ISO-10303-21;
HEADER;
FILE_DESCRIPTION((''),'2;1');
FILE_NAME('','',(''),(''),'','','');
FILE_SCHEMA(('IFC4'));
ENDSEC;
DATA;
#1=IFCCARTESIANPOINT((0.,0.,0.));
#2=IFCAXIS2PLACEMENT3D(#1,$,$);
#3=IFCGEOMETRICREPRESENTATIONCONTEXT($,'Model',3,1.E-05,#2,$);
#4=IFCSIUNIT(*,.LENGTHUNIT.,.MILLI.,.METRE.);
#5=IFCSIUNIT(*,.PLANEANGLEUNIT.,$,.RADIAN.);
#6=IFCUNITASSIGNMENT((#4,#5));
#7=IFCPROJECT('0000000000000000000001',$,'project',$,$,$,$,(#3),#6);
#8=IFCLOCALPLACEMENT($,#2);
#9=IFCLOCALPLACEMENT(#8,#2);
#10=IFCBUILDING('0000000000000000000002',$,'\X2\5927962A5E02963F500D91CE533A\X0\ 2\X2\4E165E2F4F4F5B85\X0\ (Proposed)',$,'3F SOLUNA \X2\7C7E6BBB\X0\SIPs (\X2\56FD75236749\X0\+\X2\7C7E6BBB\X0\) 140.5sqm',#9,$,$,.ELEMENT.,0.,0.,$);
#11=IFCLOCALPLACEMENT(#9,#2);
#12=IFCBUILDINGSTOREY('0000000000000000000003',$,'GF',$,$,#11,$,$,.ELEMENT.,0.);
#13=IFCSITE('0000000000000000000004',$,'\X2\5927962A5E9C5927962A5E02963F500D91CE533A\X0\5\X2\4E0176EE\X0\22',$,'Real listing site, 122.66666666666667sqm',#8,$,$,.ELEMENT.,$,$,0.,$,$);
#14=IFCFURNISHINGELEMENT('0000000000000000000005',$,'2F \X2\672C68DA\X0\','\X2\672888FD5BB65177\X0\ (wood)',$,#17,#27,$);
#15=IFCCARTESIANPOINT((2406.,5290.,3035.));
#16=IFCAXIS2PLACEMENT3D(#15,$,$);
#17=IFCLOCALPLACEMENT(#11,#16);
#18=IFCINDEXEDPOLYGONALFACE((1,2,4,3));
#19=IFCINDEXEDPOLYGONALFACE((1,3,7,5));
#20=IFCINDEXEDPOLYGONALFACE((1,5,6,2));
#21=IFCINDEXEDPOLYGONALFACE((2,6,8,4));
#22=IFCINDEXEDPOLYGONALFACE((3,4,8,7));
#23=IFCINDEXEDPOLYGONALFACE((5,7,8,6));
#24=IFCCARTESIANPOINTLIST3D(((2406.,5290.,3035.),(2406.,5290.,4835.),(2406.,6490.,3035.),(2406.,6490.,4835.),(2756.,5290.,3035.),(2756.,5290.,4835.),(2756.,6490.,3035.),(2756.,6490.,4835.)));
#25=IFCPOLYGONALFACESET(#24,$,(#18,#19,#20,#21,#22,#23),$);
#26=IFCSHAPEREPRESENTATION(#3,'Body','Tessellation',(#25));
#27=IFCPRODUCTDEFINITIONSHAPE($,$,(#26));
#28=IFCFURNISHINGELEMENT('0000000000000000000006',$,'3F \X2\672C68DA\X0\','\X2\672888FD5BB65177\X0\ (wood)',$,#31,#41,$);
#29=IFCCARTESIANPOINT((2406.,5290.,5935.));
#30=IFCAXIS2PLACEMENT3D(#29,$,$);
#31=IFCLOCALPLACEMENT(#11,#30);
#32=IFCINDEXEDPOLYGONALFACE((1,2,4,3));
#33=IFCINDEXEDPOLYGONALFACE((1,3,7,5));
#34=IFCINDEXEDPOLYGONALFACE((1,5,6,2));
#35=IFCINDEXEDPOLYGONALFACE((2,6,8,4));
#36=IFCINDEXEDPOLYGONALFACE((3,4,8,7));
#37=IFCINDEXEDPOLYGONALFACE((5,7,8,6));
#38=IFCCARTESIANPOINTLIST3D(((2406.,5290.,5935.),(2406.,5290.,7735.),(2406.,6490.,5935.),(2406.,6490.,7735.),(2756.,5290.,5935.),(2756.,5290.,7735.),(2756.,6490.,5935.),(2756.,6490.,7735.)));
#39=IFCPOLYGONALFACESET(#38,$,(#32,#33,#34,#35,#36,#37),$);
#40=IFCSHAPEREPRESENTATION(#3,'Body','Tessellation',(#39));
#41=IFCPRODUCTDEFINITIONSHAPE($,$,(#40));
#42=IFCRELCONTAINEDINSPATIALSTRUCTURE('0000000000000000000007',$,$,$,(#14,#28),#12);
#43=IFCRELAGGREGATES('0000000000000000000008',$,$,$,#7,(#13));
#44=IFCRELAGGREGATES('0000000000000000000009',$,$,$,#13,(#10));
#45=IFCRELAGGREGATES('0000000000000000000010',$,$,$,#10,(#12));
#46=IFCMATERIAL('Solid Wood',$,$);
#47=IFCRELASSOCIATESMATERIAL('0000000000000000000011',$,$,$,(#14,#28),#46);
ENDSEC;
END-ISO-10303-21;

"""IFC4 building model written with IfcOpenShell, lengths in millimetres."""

from ifc_helpers import new_model, si_unit, frame, frame_2d, origin, place, context, project, spatial, rectangle, extrude, material, element, save


model = new_model("IFC4")

# Units and contexts
model_context = context("Model", 3, precision=1e-05, world=origin())
ifc_project = project(units=[si_unit("LENGTHUNIT", "METRE", prefix="MILLI"), si_unit("PLANEANGLEUNIT", "RADIAN")], contexts=[model_context])

# Site, building, storey
site_placement = place(None, origin())
site = spatial("IfcSite", under=ifc_project, at=site_placement, Name="大阪府大阪市阿倍野区5丁目22", ObjectType="Real listing site, 122.66666666666667sqm", CompositionType="ELEMENT", RefElevation=0.0)
building_placement = place(site_placement, origin())
building = spatial("IfcBuilding", under=site, at=building_placement, Name="大阪市阿倍野区 2世帯住宅 (Proposed)", ObjectType="3F SOLUNA 籾殻SIPs (国産杉+籾殻) 140.5sqm", CompositionType="ELEMENT", ElevationOfRefHeight=0.0, ElevationOfTerrain=0.0)
storey_placement = place(building_placement, origin())
storey = spatial("IfcBuildingStorey", under=building, at=storey_placement, Name="GF", CompositionType="ELEMENT", Elevation=0.0)

# Shared definitions
ifc_material_1 = material(Name="Solid Wood")

# Furnishing elements
furnishing_1_placement = place(storey_placement, frame((2406.0, 5290.0, 3035.0)))
element("IfcFurnishingElement", 1, at=furnishing_1_placement, inside=storey, material=ifc_material_1, Name="2F 本棚", Description="木製家具 (wood)", context=model_context, shape_type="SweptSolid", body=[
    extrude(rectangle(XDim=350.0, YDim=1200.0, at=frame_2d((175.0, 600.0))), frame((2406.0, 5290.0, 3035.0)), (0.0, 0.0, 1.0), 1800.0),
])
furnishing_2_placement = place(storey_placement, frame((2406.0, 5290.0, 5935.0)))
element("IfcFurnishingElement", 2, at=furnishing_2_placement, inside=storey, material=ifc_material_1, Name="3F 本棚", Description="木製家具 (wood)", context=model_context, shape_type="SweptSolid", body=[
    extrude(rectangle(XDim=350.0, YDim=1200.0, at=frame_2d((175.0, 600.0))), frame((2406.0, 5290.0, 5935.0)), (0.0, 0.0, 1.0), 1800.0),
])

save(model, "model.ifc")
